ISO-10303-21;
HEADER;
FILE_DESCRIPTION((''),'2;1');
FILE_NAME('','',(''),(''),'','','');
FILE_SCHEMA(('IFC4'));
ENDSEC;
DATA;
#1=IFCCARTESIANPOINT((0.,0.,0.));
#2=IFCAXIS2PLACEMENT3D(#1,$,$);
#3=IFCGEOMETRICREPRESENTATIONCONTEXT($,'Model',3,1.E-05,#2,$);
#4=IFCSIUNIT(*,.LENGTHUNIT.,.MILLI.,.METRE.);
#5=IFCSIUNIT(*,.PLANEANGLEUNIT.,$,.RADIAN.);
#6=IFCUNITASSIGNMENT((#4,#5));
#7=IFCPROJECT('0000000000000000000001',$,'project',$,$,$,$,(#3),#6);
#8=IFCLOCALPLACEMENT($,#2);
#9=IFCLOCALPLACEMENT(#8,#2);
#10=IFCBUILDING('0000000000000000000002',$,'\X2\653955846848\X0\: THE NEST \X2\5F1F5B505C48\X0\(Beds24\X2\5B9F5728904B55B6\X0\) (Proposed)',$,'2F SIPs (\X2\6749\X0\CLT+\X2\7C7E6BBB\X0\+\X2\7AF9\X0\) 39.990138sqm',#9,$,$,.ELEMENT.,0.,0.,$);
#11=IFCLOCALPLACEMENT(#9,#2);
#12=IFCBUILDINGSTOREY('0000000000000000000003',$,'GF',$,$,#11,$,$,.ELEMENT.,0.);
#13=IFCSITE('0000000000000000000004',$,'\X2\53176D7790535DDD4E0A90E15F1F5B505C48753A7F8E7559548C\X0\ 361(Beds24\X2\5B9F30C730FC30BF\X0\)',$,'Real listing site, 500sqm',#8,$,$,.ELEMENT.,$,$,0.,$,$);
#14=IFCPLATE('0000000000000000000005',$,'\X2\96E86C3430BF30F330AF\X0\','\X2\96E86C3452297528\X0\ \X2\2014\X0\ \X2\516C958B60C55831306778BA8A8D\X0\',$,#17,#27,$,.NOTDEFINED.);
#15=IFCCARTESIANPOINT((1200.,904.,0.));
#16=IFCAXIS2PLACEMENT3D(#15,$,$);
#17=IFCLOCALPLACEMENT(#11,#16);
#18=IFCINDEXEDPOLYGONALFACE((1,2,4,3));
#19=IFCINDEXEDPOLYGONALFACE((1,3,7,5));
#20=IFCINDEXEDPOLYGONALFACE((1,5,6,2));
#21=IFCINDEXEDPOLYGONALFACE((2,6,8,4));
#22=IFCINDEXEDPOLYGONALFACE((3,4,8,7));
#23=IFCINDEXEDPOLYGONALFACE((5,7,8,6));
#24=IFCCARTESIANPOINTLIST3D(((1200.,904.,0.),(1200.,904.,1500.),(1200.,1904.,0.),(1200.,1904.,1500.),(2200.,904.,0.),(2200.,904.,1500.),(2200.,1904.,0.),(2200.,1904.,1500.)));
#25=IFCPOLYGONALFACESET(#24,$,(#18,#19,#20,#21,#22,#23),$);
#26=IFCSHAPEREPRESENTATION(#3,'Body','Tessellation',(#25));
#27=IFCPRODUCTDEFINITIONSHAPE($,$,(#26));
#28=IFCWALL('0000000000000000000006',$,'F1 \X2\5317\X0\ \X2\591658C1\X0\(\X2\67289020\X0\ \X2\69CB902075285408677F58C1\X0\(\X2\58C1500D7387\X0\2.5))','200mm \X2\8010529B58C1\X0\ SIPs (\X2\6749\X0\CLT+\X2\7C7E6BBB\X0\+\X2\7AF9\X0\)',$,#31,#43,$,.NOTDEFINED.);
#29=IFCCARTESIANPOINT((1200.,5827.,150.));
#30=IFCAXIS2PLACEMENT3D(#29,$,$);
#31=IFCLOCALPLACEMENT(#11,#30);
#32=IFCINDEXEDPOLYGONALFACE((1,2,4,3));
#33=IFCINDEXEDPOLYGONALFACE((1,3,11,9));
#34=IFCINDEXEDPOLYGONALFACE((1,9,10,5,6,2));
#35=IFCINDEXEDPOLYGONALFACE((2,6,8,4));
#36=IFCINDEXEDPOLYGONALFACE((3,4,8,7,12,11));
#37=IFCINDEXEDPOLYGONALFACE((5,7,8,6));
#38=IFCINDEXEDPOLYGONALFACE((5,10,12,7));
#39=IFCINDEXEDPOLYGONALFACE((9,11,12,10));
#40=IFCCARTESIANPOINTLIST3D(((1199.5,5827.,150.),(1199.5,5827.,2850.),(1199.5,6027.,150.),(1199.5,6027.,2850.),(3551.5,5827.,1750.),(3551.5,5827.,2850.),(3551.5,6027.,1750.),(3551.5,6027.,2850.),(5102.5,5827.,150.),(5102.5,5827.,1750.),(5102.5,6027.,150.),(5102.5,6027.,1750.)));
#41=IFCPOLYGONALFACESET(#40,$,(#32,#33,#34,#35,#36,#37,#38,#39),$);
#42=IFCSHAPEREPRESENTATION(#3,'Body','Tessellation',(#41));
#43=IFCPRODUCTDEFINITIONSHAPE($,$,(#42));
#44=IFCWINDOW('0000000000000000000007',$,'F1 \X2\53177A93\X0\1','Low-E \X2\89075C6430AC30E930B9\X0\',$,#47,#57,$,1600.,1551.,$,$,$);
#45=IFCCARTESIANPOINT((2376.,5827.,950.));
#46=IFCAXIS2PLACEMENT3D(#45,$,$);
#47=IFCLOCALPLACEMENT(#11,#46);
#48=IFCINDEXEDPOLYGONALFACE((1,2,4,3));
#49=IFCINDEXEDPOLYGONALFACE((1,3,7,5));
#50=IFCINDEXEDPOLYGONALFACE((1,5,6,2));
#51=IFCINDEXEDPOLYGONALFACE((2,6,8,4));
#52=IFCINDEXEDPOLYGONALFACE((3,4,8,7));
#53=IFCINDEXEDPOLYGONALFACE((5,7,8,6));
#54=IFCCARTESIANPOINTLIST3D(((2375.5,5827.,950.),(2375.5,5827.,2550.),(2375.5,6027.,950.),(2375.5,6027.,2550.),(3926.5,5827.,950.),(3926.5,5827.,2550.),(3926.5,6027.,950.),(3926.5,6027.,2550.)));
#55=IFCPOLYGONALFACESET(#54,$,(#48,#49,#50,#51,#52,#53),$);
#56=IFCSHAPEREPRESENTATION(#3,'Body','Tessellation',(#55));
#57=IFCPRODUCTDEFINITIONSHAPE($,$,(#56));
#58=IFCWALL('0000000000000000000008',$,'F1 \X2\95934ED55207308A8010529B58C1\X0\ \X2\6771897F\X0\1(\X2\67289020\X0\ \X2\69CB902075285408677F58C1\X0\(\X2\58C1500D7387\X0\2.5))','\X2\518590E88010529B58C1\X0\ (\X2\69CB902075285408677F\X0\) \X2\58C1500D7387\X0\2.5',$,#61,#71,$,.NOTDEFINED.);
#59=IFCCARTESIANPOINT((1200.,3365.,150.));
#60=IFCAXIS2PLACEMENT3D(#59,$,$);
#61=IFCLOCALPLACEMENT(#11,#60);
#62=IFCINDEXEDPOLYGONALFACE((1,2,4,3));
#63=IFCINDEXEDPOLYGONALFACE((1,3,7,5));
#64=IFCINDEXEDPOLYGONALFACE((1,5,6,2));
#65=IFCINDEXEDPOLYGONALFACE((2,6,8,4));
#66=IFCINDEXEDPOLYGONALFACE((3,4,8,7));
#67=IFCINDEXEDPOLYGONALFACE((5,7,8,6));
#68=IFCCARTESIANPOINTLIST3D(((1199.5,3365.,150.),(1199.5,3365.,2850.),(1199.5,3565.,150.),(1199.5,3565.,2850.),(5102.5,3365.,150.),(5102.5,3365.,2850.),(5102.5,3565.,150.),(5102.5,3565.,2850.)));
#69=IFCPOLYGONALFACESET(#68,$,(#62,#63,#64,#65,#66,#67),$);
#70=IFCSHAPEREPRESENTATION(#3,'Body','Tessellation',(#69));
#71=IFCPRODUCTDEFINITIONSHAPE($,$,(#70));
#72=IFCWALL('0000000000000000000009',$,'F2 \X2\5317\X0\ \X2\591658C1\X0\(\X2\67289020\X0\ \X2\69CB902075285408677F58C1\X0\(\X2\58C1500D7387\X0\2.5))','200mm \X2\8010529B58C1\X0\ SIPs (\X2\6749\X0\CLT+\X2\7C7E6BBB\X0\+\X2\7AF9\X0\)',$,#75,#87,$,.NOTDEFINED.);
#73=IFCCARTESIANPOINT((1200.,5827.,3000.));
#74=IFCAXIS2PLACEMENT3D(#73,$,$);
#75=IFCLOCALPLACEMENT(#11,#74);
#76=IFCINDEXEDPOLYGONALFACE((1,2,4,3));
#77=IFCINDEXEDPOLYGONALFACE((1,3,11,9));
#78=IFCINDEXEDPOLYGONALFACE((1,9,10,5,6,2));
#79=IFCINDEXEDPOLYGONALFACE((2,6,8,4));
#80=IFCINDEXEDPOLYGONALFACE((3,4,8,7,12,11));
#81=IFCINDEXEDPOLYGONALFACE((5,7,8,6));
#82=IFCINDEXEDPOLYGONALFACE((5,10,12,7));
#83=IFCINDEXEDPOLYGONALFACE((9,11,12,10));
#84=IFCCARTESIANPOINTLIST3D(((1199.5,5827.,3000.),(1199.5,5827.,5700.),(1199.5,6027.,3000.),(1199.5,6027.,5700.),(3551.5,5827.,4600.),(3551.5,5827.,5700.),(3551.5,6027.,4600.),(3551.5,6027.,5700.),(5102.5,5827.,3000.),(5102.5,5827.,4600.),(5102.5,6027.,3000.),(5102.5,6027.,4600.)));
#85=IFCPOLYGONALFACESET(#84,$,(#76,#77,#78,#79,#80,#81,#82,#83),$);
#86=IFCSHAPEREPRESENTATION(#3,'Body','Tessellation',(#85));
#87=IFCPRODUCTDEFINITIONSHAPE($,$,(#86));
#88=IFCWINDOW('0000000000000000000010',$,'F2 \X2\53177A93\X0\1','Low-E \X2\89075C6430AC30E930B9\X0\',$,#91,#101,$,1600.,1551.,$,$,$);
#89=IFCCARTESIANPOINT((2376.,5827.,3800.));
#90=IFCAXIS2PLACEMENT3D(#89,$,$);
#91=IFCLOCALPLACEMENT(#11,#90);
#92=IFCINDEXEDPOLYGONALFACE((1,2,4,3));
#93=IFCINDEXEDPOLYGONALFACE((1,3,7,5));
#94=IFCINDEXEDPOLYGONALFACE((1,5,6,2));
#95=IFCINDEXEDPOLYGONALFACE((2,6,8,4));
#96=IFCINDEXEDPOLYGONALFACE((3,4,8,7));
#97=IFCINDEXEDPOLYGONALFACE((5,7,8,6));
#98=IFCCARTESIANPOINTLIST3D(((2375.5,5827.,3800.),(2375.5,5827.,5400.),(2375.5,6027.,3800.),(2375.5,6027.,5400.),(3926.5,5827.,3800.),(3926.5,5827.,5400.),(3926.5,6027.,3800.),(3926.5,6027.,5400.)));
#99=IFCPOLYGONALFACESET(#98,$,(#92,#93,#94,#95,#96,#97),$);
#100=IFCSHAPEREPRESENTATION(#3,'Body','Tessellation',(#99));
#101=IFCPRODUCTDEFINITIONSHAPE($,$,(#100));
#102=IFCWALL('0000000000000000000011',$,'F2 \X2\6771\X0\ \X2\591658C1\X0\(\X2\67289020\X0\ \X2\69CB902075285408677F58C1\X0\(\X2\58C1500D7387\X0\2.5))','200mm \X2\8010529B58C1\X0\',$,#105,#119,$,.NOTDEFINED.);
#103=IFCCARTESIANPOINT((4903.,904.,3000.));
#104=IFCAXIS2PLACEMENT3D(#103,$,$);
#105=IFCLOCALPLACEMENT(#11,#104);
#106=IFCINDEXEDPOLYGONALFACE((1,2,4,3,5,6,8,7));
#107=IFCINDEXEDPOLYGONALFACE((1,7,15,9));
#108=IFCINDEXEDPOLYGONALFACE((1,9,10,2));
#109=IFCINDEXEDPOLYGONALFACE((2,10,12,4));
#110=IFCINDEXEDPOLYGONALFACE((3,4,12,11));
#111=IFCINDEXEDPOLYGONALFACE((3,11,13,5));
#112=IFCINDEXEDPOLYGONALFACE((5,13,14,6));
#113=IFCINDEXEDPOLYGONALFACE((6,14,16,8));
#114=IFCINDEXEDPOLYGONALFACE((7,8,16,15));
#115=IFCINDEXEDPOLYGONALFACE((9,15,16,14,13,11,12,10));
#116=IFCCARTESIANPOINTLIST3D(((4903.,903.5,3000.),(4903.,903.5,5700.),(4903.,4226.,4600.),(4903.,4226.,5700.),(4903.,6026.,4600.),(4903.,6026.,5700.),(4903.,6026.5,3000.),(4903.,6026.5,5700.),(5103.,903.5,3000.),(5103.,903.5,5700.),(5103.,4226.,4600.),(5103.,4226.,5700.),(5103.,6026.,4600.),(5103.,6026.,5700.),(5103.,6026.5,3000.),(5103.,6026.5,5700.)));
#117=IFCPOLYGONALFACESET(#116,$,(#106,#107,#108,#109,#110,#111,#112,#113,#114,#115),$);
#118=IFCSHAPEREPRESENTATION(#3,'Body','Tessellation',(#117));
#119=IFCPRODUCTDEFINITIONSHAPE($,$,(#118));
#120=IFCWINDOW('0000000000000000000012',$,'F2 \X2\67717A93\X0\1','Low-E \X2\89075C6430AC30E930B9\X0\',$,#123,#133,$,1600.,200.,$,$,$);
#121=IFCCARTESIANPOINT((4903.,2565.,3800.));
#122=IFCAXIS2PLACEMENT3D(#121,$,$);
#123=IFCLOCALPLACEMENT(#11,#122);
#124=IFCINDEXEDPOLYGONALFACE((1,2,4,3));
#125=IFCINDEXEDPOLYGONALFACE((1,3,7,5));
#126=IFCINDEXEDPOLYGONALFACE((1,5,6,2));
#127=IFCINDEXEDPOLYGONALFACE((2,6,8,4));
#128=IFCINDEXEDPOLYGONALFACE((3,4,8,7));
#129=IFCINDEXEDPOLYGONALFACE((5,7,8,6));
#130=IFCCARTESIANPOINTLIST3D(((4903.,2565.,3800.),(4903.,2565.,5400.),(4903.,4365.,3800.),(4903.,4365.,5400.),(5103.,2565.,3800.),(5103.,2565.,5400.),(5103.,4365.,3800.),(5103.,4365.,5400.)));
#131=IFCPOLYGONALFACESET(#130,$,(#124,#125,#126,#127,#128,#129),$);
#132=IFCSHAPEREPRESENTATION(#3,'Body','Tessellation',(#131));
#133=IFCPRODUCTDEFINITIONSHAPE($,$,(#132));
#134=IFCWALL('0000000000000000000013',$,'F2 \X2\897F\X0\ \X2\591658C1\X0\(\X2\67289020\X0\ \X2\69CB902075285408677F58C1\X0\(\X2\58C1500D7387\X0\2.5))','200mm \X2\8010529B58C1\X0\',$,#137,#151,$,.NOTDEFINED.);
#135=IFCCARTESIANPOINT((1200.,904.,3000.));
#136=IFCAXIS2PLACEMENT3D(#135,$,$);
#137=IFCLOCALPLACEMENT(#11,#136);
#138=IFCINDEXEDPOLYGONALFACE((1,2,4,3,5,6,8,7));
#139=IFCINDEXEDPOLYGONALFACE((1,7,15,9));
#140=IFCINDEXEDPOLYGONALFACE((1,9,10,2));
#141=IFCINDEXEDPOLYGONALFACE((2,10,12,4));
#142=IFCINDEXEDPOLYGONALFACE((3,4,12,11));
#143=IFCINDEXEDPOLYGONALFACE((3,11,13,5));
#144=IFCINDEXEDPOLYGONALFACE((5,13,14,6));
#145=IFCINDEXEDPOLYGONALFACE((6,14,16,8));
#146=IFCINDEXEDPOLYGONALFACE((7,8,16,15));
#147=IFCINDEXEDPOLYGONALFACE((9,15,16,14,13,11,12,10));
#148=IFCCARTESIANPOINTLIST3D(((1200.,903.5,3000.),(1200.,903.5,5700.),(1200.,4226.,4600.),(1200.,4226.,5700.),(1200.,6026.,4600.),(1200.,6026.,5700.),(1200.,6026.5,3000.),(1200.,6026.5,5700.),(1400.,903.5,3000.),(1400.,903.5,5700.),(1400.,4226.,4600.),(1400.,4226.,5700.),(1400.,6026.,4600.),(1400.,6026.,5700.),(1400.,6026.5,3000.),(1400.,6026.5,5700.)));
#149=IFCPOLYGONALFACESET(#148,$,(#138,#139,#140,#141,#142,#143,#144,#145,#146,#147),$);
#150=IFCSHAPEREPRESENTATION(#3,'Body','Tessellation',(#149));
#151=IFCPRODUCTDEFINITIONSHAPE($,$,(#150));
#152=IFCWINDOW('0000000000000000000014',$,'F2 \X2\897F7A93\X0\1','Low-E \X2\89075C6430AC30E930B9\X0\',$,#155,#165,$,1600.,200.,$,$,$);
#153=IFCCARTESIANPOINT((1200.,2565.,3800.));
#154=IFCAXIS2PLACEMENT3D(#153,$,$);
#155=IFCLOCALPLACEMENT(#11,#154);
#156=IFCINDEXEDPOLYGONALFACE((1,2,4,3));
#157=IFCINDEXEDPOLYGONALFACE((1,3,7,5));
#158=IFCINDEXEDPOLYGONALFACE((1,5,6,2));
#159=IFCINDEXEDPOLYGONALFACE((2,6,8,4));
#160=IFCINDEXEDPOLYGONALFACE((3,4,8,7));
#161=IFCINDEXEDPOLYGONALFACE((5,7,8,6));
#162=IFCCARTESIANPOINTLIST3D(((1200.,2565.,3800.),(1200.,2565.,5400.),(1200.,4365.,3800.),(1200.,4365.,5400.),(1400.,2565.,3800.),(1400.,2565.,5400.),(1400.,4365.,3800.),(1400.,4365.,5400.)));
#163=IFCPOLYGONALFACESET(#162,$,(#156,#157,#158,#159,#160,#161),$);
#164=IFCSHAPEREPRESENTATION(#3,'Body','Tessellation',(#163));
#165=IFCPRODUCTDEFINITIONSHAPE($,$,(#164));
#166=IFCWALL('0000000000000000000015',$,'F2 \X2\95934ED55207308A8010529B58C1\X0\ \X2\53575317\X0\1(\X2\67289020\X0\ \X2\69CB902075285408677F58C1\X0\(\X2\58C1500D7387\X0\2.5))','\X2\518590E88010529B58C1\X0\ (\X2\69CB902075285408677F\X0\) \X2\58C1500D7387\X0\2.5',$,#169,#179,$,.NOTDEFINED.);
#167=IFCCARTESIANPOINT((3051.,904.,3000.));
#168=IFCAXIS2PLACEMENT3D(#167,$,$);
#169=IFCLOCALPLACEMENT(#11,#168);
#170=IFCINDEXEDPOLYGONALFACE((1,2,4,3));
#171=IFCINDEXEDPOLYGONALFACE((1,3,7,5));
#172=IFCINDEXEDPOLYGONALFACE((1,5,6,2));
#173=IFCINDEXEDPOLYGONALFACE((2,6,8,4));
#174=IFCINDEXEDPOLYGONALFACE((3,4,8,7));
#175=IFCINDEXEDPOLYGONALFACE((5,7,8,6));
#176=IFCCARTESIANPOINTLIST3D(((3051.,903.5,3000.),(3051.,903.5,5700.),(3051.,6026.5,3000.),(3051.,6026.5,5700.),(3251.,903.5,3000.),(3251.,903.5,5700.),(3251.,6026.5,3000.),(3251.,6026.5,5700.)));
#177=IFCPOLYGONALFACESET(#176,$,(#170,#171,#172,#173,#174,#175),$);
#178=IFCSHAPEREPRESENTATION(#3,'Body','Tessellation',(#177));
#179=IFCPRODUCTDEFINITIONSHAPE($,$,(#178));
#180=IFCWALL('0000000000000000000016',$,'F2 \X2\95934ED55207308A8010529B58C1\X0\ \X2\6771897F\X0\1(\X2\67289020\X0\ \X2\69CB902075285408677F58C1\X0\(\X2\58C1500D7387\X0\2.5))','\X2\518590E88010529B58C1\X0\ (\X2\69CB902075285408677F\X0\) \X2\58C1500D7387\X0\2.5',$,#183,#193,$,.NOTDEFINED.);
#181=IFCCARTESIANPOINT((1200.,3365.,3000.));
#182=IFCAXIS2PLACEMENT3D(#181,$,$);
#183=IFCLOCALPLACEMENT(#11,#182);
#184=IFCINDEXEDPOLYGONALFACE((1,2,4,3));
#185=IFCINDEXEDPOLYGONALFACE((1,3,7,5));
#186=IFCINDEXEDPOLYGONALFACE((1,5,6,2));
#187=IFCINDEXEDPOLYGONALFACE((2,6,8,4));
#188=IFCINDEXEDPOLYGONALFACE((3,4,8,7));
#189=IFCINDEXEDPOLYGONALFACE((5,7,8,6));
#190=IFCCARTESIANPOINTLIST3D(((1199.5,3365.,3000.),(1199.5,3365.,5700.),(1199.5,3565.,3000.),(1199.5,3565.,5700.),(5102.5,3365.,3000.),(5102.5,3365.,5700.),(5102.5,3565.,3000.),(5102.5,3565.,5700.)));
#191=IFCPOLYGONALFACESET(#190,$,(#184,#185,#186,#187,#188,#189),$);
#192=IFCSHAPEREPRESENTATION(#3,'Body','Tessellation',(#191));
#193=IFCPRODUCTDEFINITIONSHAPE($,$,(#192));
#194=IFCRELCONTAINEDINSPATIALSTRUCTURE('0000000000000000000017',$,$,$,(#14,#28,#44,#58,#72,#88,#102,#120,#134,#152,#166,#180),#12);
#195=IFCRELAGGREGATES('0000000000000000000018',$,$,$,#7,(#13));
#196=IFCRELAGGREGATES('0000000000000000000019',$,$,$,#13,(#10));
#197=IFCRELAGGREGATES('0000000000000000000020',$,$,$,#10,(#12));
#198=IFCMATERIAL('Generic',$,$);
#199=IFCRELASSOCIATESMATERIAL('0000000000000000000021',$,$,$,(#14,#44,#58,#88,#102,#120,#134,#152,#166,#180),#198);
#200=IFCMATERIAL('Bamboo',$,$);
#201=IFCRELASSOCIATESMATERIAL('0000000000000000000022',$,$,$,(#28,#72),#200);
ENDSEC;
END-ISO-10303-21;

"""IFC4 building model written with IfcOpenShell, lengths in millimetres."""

from ifc_helpers import new_model, si_unit, frame, frame_2d, origin, place, context, project, spatial, rectangle, extrude, material, element, fill, save


model = new_model("IFC4")

# Units and contexts
model_context = context("Model", 3, precision=1e-05, world=origin())
ifc_project = project(units=[si_unit("LENGTHUNIT", "METRE", prefix="MILLI"), si_unit("PLANEANGLEUNIT", "RADIAN")], contexts=[model_context])

# Site, building, storey
site_placement = place(None, origin())
site = spatial("IfcSite", under=ifc_project, at=site_placement, Name="北海道川上郡弟子屈町美留和 361(Beds24実データ)", ObjectType="Real listing site, 500sqm", CompositionType="ELEMENT", RefElevation=0.0)
building_placement = place(site_placement, origin())
building = spatial("IfcBuilding", under=site, at=building_placement, Name="改善案: THE NEST 弟子屈(Beds24実在運営) (Proposed)", ObjectType="2F SIPs (杉CLT+籾殻+竹) 39.990138sqm", CompositionType="ELEMENT", ElevationOfRefHeight=0.0, ElevationOfTerrain=0.0)
storey_placement = place(building_placement, origin())
storey = spatial("IfcBuildingStorey", under=building, at=storey_placement, Name="GF", CompositionType="ELEMENT", Elevation=0.0)

# Plate
ifc_material_1 = material(Name="Generic")
plate_placement = place(storey_placement, frame((1200.0, 904.0, 0.0)))
element("IfcPlate", 1, at=plate_placement, inside=storey, material=ifc_material_1, Name="雨水タンク", Description="雨水利用 — 公開情報で確認", PredefinedType="NOTDEFINED", context=model_context, shape_type="SweptSolid", body=[
    extrude(rectangle(XDim=1000.0, YDim=1000.0, at=frame_2d((500.0, 500.0))), frame((1200.0, 904.0, 0.0)), (0.0, 0.0, 1.0), 1500.0),
])

# Wall, opening, window
ifc_material_2 = material(Name="Bamboo")
wall_1_placement = place(storey_placement, frame((1200.0, 5827.0, 150.0)))
wall_1 = element("IfcWall", 2, at=wall_1_placement, inside=storey, material=ifc_material_2, Name="F1 北 外壁(木造 構造用合板壁(壁倍率2.5))", Description="200mm 耐力壁 SIPs (杉CLT+籾殻+竹)", PredefinedType="NOTDEFINED", context=model_context, shape_type="SweptSolid", body=[
    extrude(rectangle(XDim=3903.0, YDim=200.0, at=frame_2d((1951.0, 100.0))), frame((1200.0, 5827.0, 150.0)), (0.0, 0.0, 1.0), 2700.0),
])
opening_1_placement = place(storey_placement, frame((2376.0, 5827.0, 950.0)))
opening_1 = element("IfcOpeningElement", 3, at=opening_1_placement, cuts=wall_1, PredefinedType="NOTDEFINED", context=model_context, shape_type="SweptSolid", body=[
    extrude(rectangle(XDim=1551.0, YDim=200.0, at=frame_2d((775.0, 100.0))), frame((2376.0, 5827.0, 950.0)), (0.0, 0.0, 1.0), 1600.0),
])
window_1_placement = place(storey_placement, frame((2376.0, 5827.0, 950.0)))
window_1 = element("IfcWindow", 4, at=window_1_placement, inside=storey, material=ifc_material_1, Name="F1 北窓1", Description="Low-E 複層ガラス", OverallHeight=1600.0, OverallWidth=1551.0, context=model_context, shape_type="SweptSolid", body=[
    extrude(rectangle(XDim=1551.0, YDim=200.0, at=frame_2d((775.0, 100.0))), frame((2376.0, 5827.0, 950.0)), (0.0, 0.0, 1.0), 1600.0),
])
fill(opening_1, window_1)

# Wall
wall_2_placement = place(storey_placement, frame((1200.0, 3365.0, 150.0)))
element("IfcWall", 5, at=wall_2_placement, inside=storey, material=ifc_material_1, Name="F1 間仕切り耐力壁 東西1(木造 構造用合板壁(壁倍率2.5))", Description="内部耐力壁 (構造用合板) 壁倍率2.5", PredefinedType="NOTDEFINED", context=model_context, shape_type="SweptSolid", body=[
    extrude(rectangle(XDim=3903.0, YDim=200.0, at=frame_2d((1951.0, 100.0))), frame((1200.0, 3365.0, 150.0)), (0.0, 0.0, 1.0), 2700.0),
])

# Walls, openings, windows
wall_3_placement = place(storey_placement, frame((1200.0, 5827.0, 3000.0)))
wall_3 = element("IfcWall", 6, at=wall_3_placement, inside=storey, material=ifc_material_2, Name="F2 北 外壁(木造 構造用合板壁(壁倍率2.5))", Description="200mm 耐力壁 SIPs (杉CLT+籾殻+竹)", PredefinedType="NOTDEFINED", context=model_context, shape_type="SweptSolid", body=[
    extrude(rectangle(XDim=3903.0, YDim=200.0, at=frame_2d((1951.0, 100.0))), frame((1200.0, 5827.0, 3000.0)), (0.0, 0.0, 1.0), 2700.0),
])
opening_2_placement = place(storey_placement, frame((2376.0, 5827.0, 3800.0)))
opening_2 = element("IfcOpeningElement", 7, at=opening_2_placement, cuts=wall_3, PredefinedType="NOTDEFINED", context=model_context, shape_type="SweptSolid", body=[
    extrude(rectangle(XDim=1551.0, YDim=200.0, at=frame_2d((775.0, 100.0))), frame((2376.0, 5827.0, 3800.0)), (0.0, 0.0, 1.0), 1600.0),
])
window_2_placement = place(storey_placement, frame((2376.0, 5827.0, 3800.0)))
window_2 = element("IfcWindow", 8, at=window_2_placement, inside=storey, material=ifc_material_1, Name="F2 北窓1", Description="Low-E 複層ガラス", OverallHeight=1600.0, OverallWidth=1551.0, context=model_context, shape_type="SweptSolid", body=[
    extrude(rectangle(XDim=1551.0, YDim=200.0, at=frame_2d((775.0, 100.0))), frame((2376.0, 5827.0, 3800.0)), (0.0, 0.0, 1.0), 1600.0),
])
fill(opening_2, window_2)
wall_4_placement = place(storey_placement, frame((4903.0, 904.0, 3000.0)))
wall_4 = element("IfcWall", 9, at=wall_4_placement, inside=storey, material=ifc_material_1, Name="F2 東 外壁(木造 構造用合板壁(壁倍率2.5))", Description="200mm 耐力壁", PredefinedType="NOTDEFINED", context=model_context, shape_type="SweptSolid", body=[
    extrude(rectangle(XDim=200.0, YDim=5123.0, at=frame_2d((100.0, 2561.0))), frame((4903.0, 904.0, 3000.0)), (0.0, 0.0, 1.0), 2700.0),
])
opening_3_placement = place(storey_placement, frame((4903.0, 2565.0, 3800.0)))
opening_3 = element("IfcOpeningElement", 10, at=opening_3_placement, cuts=wall_4, PredefinedType="NOTDEFINED", context=model_context, shape_type="SweptSolid", body=[
    extrude(rectangle(XDim=200.0, YDim=1800.0, at=frame_2d((100.0, 900.0))), frame((4903.0, 2565.0, 3800.0)), (0.0, 0.0, 1.0), 1600.0),
])
window_3_placement = place(storey_placement, frame((4903.0, 2565.0, 3800.0)))
window_3 = element("IfcWindow", 11, at=window_3_placement, inside=storey, material=ifc_material_1, Name="F2 東窓1", Description="Low-E 複層ガラス", OverallHeight=1600.0, OverallWidth=200.0, context=model_context, shape_type="SweptSolid", body=[
    extrude(rectangle(XDim=200.0, YDim=1800.0, at=frame_2d((100.0, 900.0))), frame((4903.0, 2565.0, 3800.0)), (0.0, 0.0, 1.0), 1600.0),
])
fill(opening_3, window_3)
wall_5_placement = place(storey_placement, frame((1200.0, 904.0, 3000.0)))
wall_5 = element("IfcWall", 12, at=wall_5_placement, inside=storey, material=ifc_material_1, Name="F2 西 外壁(木造 構造用合板壁(壁倍率2.5))", Description="200mm 耐力壁", PredefinedType="NOTDEFINED", context=model_context, shape_type="SweptSolid", body=[
    extrude(rectangle(XDim=200.0, YDim=5123.0, at=frame_2d((100.0, 2561.0))), frame((1200.0, 904.0, 3000.0)), (0.0, 0.0, 1.0), 2700.0),
])
opening_4_placement = place(storey_placement, frame((1200.0, 2565.0, 3800.0)))
opening_4 = element("IfcOpeningElement", 13, at=opening_4_placement, cuts=wall_5, PredefinedType="NOTDEFINED", context=model_context, shape_type="SweptSolid", body=[
    extrude(rectangle(XDim=200.0, YDim=1800.0, at=frame_2d((100.0, 900.0))), frame((1200.0, 2565.0, 3800.0)), (0.0, 0.0, 1.0), 1600.0),
])
window_4_placement = place(storey_placement, frame((1200.0, 2565.0, 3800.0)))
window_4 = element("IfcWindow", 14, at=window_4_placement, inside=storey, material=ifc_material_1, Name="F2 西窓1", Description="Low-E 複層ガラス", OverallHeight=1600.0, OverallWidth=200.0, context=model_context, shape_type="SweptSolid", body=[
    extrude(rectangle(XDim=200.0, YDim=1800.0, at=frame_2d((100.0, 900.0))), frame((1200.0, 2565.0, 3800.0)), (0.0, 0.0, 1.0), 1600.0),
])
fill(opening_4, window_4)

# Walls
wall_6_placement = place(storey_placement, frame((3051.0, 904.0, 3000.0)))
element("IfcWall", 15, at=wall_6_placement, inside=storey, material=ifc_material_1, Name="F2 間仕切り耐力壁 南北1(木造 構造用合板壁(壁倍率2.5))", Description="内部耐力壁 (構造用合板) 壁倍率2.5", PredefinedType="NOTDEFINED", context=model_context, shape_type="SweptSolid", body=[
    extrude(rectangle(XDim=200.0, YDim=5123.0, at=frame_2d((100.0, 2561.0))), frame((3051.0, 904.0, 3000.0)), (0.0, 0.0, 1.0), 2700.0),
])
wall_7_placement = place(storey_placement, frame((1200.0, 3365.0, 3000.0)))
element("IfcWall", 16, at=wall_7_placement, inside=storey, material=ifc_material_1, Name="F2 間仕切り耐力壁 東西1(木造 構造用合板壁(壁倍率2.5))", Description="内部耐力壁 (構造用合板) 壁倍率2.5", PredefinedType="NOTDEFINED", context=model_context, shape_type="SweptSolid", body=[
    extrude(rectangle(XDim=3903.0, YDim=200.0, at=frame_2d((1951.0, 100.0))), frame((1200.0, 3365.0, 3000.0)), (0.0, 0.0, 1.0), 2700.0),
])

save(model, "model.ifc")
